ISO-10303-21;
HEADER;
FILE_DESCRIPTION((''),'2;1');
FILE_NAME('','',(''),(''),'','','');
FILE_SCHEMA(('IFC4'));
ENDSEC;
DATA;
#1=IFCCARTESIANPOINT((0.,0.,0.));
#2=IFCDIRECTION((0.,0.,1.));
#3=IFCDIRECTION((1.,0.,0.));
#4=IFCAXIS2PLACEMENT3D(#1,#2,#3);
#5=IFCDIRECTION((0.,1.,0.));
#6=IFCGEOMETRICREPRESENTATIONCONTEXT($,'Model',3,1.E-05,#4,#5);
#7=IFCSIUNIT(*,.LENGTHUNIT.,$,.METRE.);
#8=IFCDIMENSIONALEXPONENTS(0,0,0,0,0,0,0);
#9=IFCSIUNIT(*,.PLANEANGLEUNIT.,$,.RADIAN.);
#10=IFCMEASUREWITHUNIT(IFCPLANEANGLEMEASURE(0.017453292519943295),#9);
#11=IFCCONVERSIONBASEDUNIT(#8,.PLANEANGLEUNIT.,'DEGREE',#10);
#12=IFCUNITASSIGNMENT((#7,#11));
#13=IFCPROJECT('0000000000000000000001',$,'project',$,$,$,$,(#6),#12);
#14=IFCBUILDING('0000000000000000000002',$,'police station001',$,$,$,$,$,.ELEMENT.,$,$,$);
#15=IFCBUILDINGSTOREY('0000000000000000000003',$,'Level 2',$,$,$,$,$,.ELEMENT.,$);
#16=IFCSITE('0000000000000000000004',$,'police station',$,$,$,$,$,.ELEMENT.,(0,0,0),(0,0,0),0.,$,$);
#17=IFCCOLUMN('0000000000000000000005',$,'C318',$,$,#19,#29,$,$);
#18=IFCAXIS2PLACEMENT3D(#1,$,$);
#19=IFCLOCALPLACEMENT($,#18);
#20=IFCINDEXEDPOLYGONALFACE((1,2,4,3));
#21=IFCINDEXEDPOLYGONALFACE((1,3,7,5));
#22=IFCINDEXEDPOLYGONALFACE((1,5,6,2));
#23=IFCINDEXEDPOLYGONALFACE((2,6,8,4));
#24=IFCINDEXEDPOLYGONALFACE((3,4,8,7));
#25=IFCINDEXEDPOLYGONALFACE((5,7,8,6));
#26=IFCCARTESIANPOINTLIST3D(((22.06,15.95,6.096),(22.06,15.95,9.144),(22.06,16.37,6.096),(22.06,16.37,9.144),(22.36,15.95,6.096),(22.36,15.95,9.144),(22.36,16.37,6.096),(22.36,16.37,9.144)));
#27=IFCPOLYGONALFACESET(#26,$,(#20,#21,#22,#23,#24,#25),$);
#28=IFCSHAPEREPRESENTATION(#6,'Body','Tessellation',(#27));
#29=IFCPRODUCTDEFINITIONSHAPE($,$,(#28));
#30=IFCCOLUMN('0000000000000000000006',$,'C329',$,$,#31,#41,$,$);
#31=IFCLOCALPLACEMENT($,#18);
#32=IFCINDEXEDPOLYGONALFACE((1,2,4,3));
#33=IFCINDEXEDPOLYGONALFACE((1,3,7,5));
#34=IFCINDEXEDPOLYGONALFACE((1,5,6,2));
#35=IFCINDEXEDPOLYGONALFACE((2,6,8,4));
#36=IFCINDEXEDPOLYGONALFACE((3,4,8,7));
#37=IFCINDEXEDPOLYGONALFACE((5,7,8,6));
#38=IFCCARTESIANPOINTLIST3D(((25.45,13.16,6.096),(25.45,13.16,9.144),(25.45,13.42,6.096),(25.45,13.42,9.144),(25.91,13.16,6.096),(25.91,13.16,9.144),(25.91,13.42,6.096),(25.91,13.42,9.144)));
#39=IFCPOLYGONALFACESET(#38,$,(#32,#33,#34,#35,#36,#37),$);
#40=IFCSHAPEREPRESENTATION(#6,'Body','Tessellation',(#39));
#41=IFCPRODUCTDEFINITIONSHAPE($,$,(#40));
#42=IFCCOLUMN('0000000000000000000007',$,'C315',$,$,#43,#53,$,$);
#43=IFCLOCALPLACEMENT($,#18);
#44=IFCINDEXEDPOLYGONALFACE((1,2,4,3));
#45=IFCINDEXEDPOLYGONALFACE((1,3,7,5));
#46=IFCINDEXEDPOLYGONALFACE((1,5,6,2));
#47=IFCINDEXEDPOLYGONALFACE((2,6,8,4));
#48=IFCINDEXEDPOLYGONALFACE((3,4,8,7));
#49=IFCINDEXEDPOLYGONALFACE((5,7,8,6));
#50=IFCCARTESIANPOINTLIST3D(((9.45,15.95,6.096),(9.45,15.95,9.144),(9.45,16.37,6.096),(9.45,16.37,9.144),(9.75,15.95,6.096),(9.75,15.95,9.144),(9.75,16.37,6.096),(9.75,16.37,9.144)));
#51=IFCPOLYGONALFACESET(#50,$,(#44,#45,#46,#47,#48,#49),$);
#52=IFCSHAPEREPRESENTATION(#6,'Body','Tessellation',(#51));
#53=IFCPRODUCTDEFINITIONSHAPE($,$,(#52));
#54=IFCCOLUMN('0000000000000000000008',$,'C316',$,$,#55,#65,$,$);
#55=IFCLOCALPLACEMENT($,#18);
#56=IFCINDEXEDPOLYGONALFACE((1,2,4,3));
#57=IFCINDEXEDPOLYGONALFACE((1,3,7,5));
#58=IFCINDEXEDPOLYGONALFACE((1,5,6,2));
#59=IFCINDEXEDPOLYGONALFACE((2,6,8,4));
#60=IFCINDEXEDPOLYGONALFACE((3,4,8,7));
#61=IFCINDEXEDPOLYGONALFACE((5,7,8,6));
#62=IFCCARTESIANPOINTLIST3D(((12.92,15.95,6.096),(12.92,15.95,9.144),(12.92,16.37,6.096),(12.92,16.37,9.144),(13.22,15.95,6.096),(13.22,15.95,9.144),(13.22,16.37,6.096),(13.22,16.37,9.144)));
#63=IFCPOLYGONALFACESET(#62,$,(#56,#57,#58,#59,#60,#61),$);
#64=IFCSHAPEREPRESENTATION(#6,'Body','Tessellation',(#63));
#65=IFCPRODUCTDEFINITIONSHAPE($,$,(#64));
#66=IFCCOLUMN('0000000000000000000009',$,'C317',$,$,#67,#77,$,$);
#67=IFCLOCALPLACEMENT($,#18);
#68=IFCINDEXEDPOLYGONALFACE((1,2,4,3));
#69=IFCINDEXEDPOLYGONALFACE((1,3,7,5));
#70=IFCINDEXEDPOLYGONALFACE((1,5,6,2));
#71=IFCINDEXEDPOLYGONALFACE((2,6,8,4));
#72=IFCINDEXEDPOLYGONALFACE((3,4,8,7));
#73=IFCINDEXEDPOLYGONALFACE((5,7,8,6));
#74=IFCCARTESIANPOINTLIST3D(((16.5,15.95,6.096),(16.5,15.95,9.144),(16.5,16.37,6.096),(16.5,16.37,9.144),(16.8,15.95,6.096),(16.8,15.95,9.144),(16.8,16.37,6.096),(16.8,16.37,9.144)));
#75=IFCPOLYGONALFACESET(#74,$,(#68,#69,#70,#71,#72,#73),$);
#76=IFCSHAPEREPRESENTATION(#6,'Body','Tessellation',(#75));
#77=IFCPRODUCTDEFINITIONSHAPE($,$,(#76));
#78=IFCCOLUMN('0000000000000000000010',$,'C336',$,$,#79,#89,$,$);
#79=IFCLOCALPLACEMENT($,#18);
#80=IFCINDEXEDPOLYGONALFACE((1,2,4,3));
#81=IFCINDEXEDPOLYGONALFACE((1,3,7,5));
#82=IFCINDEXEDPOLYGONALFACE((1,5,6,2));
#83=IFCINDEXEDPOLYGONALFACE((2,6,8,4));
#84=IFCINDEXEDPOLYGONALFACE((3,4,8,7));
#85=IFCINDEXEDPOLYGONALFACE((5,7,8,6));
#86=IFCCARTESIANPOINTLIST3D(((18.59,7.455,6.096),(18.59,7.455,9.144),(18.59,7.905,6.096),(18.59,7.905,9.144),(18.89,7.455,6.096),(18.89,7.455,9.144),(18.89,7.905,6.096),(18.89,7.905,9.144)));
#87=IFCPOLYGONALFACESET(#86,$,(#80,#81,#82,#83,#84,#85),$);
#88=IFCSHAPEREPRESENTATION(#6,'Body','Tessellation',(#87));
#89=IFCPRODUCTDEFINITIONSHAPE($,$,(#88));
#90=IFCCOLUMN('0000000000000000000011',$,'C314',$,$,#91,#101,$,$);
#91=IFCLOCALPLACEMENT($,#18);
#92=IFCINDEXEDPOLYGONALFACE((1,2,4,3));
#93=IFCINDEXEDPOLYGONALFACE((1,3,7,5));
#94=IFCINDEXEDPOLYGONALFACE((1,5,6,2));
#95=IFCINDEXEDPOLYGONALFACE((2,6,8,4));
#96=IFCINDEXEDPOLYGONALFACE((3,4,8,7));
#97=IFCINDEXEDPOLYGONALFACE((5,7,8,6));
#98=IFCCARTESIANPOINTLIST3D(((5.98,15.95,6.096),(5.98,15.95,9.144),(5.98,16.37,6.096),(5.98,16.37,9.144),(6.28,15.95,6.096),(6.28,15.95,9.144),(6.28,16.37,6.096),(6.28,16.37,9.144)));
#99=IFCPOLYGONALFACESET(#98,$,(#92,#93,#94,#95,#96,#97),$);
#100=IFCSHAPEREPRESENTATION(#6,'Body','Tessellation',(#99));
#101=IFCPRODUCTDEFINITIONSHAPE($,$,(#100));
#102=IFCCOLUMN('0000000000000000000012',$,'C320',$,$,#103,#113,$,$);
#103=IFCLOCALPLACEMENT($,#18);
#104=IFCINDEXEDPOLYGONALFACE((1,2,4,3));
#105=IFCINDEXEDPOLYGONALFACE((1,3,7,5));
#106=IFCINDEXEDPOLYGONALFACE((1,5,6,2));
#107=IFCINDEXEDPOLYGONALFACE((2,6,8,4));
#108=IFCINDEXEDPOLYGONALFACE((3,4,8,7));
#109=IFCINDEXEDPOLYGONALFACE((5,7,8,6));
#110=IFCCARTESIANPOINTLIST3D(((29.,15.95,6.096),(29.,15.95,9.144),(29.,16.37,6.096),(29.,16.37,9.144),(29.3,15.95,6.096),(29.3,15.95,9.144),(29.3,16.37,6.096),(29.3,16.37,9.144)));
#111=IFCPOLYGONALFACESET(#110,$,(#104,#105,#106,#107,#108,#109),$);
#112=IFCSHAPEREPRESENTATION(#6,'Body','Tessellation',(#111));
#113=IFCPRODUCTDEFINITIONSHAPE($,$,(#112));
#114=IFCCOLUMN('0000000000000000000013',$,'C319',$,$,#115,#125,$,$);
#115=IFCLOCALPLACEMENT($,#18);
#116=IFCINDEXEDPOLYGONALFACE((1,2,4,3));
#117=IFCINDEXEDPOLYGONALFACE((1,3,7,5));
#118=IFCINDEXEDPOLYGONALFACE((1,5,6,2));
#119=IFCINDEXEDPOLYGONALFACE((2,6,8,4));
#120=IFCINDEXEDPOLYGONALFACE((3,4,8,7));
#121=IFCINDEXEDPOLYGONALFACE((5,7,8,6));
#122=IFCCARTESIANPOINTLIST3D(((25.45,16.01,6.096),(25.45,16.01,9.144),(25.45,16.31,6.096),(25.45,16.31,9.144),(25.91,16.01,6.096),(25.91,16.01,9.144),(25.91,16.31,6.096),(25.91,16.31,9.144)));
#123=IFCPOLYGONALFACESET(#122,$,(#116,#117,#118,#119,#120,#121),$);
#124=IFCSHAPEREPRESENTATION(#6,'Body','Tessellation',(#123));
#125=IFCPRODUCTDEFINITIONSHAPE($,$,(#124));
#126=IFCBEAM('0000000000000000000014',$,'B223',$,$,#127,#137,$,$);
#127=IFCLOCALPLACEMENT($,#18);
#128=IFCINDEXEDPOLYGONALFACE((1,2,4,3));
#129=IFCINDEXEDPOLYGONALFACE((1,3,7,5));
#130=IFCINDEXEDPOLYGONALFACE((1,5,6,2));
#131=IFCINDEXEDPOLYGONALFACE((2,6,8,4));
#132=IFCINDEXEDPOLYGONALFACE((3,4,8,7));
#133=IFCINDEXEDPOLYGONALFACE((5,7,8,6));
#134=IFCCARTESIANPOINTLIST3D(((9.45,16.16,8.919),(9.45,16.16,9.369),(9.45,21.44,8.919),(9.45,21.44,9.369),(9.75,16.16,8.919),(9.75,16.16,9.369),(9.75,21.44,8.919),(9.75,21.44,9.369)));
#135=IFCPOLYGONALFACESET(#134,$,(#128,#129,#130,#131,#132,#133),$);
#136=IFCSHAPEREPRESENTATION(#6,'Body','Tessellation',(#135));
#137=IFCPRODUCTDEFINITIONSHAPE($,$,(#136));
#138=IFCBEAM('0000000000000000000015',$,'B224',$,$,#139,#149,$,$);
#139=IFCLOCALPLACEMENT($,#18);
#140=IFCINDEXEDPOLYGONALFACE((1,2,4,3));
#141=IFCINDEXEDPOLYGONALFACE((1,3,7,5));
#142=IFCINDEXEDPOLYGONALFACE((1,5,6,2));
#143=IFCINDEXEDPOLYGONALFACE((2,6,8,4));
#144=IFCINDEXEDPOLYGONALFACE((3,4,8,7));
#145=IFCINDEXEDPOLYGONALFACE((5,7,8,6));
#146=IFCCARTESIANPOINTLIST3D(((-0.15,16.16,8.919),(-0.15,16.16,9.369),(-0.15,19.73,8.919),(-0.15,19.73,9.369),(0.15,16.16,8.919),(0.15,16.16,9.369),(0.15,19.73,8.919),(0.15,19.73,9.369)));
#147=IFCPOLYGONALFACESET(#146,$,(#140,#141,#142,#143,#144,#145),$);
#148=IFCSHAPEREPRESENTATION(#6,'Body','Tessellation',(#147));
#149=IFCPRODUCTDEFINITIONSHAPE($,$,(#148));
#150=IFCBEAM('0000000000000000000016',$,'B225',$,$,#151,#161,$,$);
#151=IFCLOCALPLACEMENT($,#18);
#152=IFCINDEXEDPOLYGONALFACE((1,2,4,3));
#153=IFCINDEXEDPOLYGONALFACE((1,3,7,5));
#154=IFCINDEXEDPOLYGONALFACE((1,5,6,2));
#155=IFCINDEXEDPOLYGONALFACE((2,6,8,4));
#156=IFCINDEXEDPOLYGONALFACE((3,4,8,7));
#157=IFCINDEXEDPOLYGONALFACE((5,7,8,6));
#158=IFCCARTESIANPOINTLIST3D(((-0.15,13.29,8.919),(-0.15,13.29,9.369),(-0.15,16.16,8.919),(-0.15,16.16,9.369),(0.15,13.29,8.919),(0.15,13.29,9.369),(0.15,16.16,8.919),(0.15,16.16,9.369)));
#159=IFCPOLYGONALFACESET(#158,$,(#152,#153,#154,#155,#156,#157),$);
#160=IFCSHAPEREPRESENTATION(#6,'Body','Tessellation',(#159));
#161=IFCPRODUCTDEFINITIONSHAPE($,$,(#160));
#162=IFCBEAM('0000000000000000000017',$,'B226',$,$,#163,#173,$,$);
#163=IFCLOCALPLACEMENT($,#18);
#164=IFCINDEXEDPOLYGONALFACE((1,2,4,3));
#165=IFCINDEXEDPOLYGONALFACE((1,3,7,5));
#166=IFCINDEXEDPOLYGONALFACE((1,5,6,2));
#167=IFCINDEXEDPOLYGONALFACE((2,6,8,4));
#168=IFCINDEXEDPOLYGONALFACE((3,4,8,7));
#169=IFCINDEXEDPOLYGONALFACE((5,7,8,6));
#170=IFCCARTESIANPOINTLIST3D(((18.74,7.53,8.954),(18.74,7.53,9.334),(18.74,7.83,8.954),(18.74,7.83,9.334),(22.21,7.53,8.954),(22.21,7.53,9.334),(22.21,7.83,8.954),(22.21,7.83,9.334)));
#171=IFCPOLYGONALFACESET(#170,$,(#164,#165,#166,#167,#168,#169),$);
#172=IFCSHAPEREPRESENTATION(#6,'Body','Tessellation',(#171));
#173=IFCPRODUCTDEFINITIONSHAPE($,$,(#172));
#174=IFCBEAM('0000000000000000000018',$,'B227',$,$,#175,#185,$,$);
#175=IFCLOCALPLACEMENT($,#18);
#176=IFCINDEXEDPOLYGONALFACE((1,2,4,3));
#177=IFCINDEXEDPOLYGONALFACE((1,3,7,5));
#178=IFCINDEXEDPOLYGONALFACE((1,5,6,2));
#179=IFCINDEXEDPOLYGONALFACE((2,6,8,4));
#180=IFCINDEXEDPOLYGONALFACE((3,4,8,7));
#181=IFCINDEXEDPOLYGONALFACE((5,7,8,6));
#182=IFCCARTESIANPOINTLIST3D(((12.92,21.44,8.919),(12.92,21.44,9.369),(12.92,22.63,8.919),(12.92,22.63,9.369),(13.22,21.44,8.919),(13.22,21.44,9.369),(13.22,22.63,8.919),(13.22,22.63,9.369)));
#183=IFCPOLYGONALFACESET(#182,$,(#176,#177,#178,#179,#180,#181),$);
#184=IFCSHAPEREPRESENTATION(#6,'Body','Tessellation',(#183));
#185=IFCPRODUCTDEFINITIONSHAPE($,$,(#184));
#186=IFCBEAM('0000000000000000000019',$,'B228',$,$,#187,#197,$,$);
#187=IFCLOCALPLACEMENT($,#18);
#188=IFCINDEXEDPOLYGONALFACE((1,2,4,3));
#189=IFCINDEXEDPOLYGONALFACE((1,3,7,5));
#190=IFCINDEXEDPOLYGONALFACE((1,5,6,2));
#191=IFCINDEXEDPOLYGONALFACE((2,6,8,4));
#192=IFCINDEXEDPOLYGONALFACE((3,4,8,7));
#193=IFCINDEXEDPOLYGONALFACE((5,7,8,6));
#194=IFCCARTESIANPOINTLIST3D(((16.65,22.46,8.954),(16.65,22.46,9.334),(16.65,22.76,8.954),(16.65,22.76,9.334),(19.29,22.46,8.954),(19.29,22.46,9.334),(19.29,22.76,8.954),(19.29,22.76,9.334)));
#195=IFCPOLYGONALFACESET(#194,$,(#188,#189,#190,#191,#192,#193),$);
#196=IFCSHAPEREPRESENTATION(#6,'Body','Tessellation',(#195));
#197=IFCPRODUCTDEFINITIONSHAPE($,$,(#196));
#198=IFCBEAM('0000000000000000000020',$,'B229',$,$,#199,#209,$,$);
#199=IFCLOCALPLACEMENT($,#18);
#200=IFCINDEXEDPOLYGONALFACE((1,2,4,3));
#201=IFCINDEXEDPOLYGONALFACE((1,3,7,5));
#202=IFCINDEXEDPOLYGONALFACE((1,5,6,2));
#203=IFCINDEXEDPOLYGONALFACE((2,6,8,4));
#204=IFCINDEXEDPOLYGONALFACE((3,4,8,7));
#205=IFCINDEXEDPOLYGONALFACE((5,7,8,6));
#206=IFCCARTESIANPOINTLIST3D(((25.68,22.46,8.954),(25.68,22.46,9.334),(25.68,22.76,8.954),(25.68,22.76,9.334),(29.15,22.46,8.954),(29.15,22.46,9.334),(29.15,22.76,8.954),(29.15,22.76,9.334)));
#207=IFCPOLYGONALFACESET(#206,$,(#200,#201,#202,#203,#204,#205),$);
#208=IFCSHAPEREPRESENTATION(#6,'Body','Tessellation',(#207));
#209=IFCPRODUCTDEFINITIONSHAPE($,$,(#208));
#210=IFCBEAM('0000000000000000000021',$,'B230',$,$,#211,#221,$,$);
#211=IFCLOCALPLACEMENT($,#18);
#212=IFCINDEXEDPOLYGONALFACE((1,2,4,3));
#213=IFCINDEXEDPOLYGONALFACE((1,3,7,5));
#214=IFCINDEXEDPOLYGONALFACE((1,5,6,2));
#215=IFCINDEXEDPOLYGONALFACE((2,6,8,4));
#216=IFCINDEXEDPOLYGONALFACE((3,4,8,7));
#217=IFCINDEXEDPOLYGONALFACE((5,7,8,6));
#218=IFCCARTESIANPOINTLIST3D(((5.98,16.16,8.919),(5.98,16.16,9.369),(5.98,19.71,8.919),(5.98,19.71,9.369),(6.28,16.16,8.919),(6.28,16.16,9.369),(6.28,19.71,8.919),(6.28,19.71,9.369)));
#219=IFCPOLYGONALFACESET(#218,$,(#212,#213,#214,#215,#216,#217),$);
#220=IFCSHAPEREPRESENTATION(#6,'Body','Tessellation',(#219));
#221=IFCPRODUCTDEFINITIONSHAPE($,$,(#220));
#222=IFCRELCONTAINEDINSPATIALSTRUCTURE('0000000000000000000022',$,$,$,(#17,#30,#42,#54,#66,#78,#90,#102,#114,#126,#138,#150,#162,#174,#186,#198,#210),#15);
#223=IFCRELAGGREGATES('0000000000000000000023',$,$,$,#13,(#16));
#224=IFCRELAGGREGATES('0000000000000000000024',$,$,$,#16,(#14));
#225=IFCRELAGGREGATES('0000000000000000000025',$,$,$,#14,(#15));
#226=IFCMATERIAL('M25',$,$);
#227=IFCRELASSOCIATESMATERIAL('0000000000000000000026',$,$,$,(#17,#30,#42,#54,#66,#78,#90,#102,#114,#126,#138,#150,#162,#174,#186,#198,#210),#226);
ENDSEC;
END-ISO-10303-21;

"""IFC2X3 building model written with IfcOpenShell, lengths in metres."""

from ifc_helpers import new_model, entity, si_unit, converted_unit, direction, frame, frame_2d, origin_with_axes, place, context, project, spatial, rectangle, extrude, material, element, save


model = new_model("IFC2X3")

# Units and contexts
model_context = context("Model", 3, precision=1e-05, world=origin_with_axes(), true_north=direction((0.0, 1.0, 0.0)))
ifc_project = project(units=[si_unit("LENGTHUNIT", "METRE"), converted_unit("PLANEANGLEUNIT", "DEGREE", entity("IfcPlaneAngleMeasure", 0.017453292519943295), si_unit("PLANEANGLEUNIT", "RADIAN"), dimensions=[0, 0, 0, 0, 0, 0, 0])], contexts=[model_context])

# Site, building, storey
site = spatial("IfcSite", under=ifc_project, Name="police station", CompositionType="ELEMENT", RefLatitude=(0, 0, 0), RefLongitude=(0, 0, 0), RefElevation=0.0)
building = spatial("IfcBuilding", under=site, Name="police station001", CompositionType="ELEMENT")
storey = spatial("IfcBuildingStorey", under=building, Name="Level 2", CompositionType="ELEMENT")

# Columns
ifc_material = material(Name="M25")
placement = place(None, origin_with_axes())
element("IfcColumn", 1, at=placement, inside=storey, material=ifc_material, Name="C318", context=model_context, shape_type="SweptSolid", body=[
    extrude(rectangle(XDim=0.3, YDim=0.42, at=frame_2d((0.0, 0.0), x_axis=(1.0, 0.0, 0.0))), frame((22.21, 16.16, 6.096), z_axis=(0.0, 0.0, 1.0), x_axis=(1.0, 0.0, 0.0)), (0.0, 0.0, 1.0), 3.048),
])
element("IfcColumn", 2, at=placement, inside=storey, material=ifc_material, Name="C329", context=model_context, shape_type="SweptSolid", body=[
    extrude(rectangle(XDim=0.46, YDim=0.26, at=frame_2d((0.0, 0.0), x_axis=(1.0, 0.0, 0.0))), frame((25.68, 13.29, 6.096), z_axis=(0.0, 0.0, 1.0), x_axis=(1.0, 0.0, 0.0)), (0.0, 0.0, 1.0), 3.048),
])
element("IfcColumn", 3, at=placement, inside=storey, material=ifc_material, Name="C315", context=model_context, shape_type="SweptSolid", body=[
    extrude(rectangle(XDim=0.3, YDim=0.42, at=frame_2d((0.0, 0.0), x_axis=(1.0, 0.0, 0.0))), frame((9.6, 16.16, 6.096), z_axis=(0.0, 0.0, 1.0), x_axis=(1.0, 0.0, 0.0)), (0.0, 0.0, 1.0), 3.048),
])
element("IfcColumn", 4, at=placement, inside=storey, material=ifc_material, Name="C316", context=model_context, shape_type="SweptSolid", body=[
    extrude(rectangle(XDim=0.3, YDim=0.42, at=frame_2d((0.0, 0.0), x_axis=(1.0, 0.0, 0.0))), frame((13.07, 16.16, 6.096), z_axis=(0.0, 0.0, 1.0), x_axis=(1.0, 0.0, 0.0)), (0.0, 0.0, 1.0), 3.048),
])
element("IfcColumn", 5, at=placement, inside=storey, material=ifc_material, Name="C317", context=model_context, shape_type="SweptSolid", body=[
    extrude(rectangle(XDim=0.3, YDim=0.42, at=frame_2d((0.0, 0.0), x_axis=(1.0, 0.0, 0.0))), frame((16.65, 16.16, 6.096), z_axis=(0.0, 0.0, 1.0), x_axis=(1.0, 0.0, 0.0)), (0.0, 0.0, 1.0), 3.048),
])
element("IfcColumn", 6, at=placement, inside=storey, material=ifc_material, Name="C336", context=model_context, shape_type="SweptSolid", body=[
    extrude(rectangle(XDim=0.3, YDim=0.45, at=frame_2d((0.0, 0.0), x_axis=(1.0, 0.0, 0.0))), frame((18.74, 7.68, 6.096), z_axis=(0.0, 0.0, 1.0), x_axis=(1.0, 0.0, 0.0)), (0.0, 0.0, 1.0), 3.048),
])
element("IfcColumn", 7, at=placement, inside=storey, material=ifc_material, Name="C314", context=model_context, shape_type="SweptSolid", body=[
    extrude(rectangle(XDim=0.3, YDim=0.42, at=frame_2d((0.0, 0.0), x_axis=(1.0, 0.0, 0.0))), frame((6.13, 16.16, 6.096), z_axis=(0.0, 0.0, 1.0), x_axis=(1.0, 0.0, 0.0)), (0.0, 0.0, 1.0), 3.048),
])
element("IfcColumn", 8, at=placement, inside=storey, material=ifc_material, Name="C320", context=model_context, shape_type="SweptSolid", body=[
    extrude(rectangle(XDim=0.3, YDim=0.42, at=frame_2d((0.0, 0.0), x_axis=(1.0, 0.0, 0.0))), frame((29.15, 16.16, 6.096), z_axis=(0.0, 0.0, 1.0), x_axis=(1.0, 0.0, 0.0)), (0.0, 0.0, 1.0), 3.048),
])
element("IfcColumn", 9, at=placement, inside=storey, material=ifc_material, Name="C319", context=model_context, shape_type="SweptSolid", body=[
    extrude(rectangle(XDim=0.46, YDim=0.3, at=frame_2d((0.0, 0.0), x_axis=(1.0, 0.0, 0.0))), frame((25.68, 16.16, 6.096), z_axis=(0.0, 0.0, 1.0), x_axis=(1.0, 0.0, 0.0)), (0.0, 0.0, 1.0), 3.048),
])

# Beams
element("IfcBeam", 10, at=placement, inside=storey, material=ifc_material, Name="B223", context=model_context, shape_type="SweptSolid", body=[
    extrude(rectangle(XDim=0.3, YDim=0.45, at=frame_2d((0.0, 0.0), x_axis=(0.0, 1.0, 0.0))), frame((9.6, 16.16, 9.144), z_axis=(0.0, 1.0, 0.0), x_axis=(0.0, 0.0, -1.0)), (0.0, 0.0, 1.0), 5.28),
])
element("IfcBeam", 11, at=placement, inside=storey, material=ifc_material, Name="B224", context=model_context, shape_type="SweptSolid", body=[
    extrude(rectangle(XDim=0.3, YDim=0.45, at=frame_2d((0.0, 0.0), x_axis=(0.0, 1.0, 0.0))), frame((0.0, 19.73, 9.144), z_axis=(0.0, -1.0, 0.0), x_axis=(0.0, 0.0, -1.0)), (0.0, 0.0, 1.0), 3.57),
])
element("IfcBeam", 12, at=placement, inside=storey, material=ifc_material, Name="B225", context=model_context, shape_type="SweptSolid", body=[
    extrude(rectangle(XDim=0.3, YDim=0.45, at=frame_2d((0.0, 0.0), x_axis=(0.0, 1.0, 0.0))), frame((0.0, 13.29, 9.144), z_axis=(0.0, 1.0, 0.0), x_axis=(0.0, 0.0, -1.0)), (0.0, 0.0, 1.0), 2.87),
])
element("IfcBeam", 13, at=placement, inside=storey, material=ifc_material, Name="B226", context=model_context, shape_type="SweptSolid", body=[
    extrude(rectangle(XDim=0.3, YDim=0.38, at=frame_2d((0.0, 0.0), x_axis=(0.0, 1.0, 0.0))), frame((18.74, 7.68, 9.144), z_axis=(1.0, 0.0, 0.0), x_axis=(0.0, 0.0, -1.0)), (0.0, 0.0, 1.0), 3.47),
])
element("IfcBeam", 14, at=placement, inside=storey, material=ifc_material, Name="B227", context=model_context, shape_type="SweptSolid", body=[
    extrude(rectangle(XDim=0.3, YDim=0.45, at=frame_2d((0.0, 0.0), x_axis=(0.0, 1.0, 0.0))), frame((13.07, 21.44, 9.144), z_axis=(0.0, 1.0, 0.0), x_axis=(0.0, 0.0, -1.0)), (0.0, 0.0, 1.0), 1.19),
])
element("IfcBeam", 15, at=placement, inside=storey, material=ifc_material, Name="B228", context=model_context, shape_type="SweptSolid", body=[
    extrude(rectangle(XDim=0.3, YDim=0.38, at=frame_2d((0.0, 0.0), x_axis=(0.0, 1.0, 0.0))), frame((19.29, 22.61, 9.144), z_axis=(-1.0, 0.0, 0.0), x_axis=(0.0, 0.0, -1.0)), (0.0, 0.0, 1.0), 2.64),
])
element("IfcBeam", 16, at=placement, inside=storey, material=ifc_material, Name="B229", context=model_context, shape_type="SweptSolid", body=[
    extrude(rectangle(XDim=0.3, YDim=0.38, at=frame_2d((0.0, 0.0), x_axis=(0.0, 1.0, 0.0))), frame((29.15, 22.61, 9.144), z_axis=(-1.0, 0.0, 0.0), x_axis=(0.0, 0.0, -1.0)), (0.0, 0.0, 1.0), 3.47),
])
element("IfcBeam", 17, at=placement, inside=storey, material=ifc_material, Name="B230", context=model_context, shape_type="SweptSolid", body=[
    extrude(rectangle(XDim=0.3, YDim=0.45, at=frame_2d((0.0, 0.0), x_axis=(0.0, 1.0, 0.0))), frame((6.13, 16.16, 9.144), z_axis=(0.0, 1.0, 0.0), x_axis=(0.0, 0.0, -1.0)), (0.0, 0.0, 1.0), 3.55),
])

save(model, "model.ifc")
